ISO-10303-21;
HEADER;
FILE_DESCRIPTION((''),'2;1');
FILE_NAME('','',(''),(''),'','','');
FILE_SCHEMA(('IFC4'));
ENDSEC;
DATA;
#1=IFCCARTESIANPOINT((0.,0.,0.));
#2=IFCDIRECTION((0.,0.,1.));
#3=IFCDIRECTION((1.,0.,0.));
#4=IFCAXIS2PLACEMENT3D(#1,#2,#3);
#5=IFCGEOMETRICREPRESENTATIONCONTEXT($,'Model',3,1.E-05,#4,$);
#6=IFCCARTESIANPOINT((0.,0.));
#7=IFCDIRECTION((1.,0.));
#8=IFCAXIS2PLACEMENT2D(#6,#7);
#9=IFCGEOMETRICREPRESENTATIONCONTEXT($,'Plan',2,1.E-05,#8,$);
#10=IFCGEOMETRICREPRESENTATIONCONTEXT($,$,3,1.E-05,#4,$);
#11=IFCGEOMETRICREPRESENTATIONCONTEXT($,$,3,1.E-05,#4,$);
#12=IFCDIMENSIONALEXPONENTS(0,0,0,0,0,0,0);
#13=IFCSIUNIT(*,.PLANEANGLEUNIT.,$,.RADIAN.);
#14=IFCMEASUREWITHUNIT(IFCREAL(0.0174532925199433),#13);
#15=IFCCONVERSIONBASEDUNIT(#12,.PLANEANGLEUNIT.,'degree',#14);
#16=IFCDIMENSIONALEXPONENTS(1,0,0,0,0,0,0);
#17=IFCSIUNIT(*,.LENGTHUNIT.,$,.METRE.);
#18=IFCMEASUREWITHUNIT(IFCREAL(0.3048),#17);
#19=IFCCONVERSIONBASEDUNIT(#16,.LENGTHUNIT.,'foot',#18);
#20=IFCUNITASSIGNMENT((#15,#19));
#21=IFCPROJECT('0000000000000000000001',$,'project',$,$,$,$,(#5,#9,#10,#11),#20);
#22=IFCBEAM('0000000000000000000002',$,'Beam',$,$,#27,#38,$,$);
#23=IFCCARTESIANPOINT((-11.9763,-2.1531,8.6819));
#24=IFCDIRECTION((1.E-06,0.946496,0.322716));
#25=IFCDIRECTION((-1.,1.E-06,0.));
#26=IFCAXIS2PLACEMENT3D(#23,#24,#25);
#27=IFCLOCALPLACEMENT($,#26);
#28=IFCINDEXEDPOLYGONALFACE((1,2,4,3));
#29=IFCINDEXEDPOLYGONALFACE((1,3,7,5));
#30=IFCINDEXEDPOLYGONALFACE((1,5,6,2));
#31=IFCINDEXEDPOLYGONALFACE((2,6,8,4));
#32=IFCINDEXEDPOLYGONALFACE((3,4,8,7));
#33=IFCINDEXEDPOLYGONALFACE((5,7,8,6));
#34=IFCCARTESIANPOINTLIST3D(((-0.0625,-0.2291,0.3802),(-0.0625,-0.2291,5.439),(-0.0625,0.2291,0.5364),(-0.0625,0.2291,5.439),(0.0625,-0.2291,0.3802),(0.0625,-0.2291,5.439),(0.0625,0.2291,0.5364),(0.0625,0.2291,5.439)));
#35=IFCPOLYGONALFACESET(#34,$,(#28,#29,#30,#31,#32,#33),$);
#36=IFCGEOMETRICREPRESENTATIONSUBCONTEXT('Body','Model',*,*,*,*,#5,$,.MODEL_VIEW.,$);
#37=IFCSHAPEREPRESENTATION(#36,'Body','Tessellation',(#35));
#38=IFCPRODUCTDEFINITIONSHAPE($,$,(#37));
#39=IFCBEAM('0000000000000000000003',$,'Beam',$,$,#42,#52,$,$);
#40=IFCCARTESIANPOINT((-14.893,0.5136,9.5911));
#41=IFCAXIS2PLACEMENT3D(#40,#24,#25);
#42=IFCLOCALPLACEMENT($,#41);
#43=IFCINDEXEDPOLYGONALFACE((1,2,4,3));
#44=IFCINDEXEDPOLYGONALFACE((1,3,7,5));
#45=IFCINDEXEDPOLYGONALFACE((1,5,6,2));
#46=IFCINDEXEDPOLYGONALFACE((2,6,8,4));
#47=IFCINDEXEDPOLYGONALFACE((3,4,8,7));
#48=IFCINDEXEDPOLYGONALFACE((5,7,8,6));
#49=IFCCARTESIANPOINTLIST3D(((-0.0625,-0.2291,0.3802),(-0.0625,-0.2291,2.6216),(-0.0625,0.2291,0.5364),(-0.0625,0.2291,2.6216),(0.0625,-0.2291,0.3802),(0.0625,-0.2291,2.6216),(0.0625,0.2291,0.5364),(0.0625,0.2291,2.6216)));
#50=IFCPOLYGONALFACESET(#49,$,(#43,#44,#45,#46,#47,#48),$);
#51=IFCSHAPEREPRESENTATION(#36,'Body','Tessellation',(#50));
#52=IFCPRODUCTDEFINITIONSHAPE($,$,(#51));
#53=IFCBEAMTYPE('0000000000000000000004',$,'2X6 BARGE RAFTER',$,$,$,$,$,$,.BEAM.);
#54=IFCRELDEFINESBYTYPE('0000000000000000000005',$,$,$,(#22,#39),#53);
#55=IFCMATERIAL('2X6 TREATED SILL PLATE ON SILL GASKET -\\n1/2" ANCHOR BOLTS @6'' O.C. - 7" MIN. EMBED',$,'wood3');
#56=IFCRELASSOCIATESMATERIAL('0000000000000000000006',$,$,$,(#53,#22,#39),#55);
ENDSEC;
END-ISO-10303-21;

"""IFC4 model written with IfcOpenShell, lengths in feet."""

from ifc_helpers import new_model, entity, si_unit, converted_unit, frame, origin_with_axes, origin_2d_with_axis, place, context, subcontext, project, rectangle, extrude, clip, halfspace, material, material_profile, profile_set, profile_usage, type_object, element, save


model = new_model("IFC4")

# Units and contexts
model_context = context("Model", 3, precision=1e-05, world=origin_with_axes())
plan_context = context("Plan", 2, precision=1e-05, world=origin_2d_with_axis())
context_of_model_1 = context(None, 3, precision=1e-05, world=origin_with_axes())
context_of_model_2 = context(None, 3, precision=1e-05, world=origin_with_axes())
body_context = subcontext(model_context, "Body", "Model", "MODEL_VIEW")
ifc_project = project(units=[converted_unit("PLANEANGLEUNIT", "degree", entity("IfcReal", 0.0174532925199433), si_unit("PLANEANGLEUNIT", "RADIAN"), dimensions=[0, 0, 0, 0, 0, 0, 0]), converted_unit("LENGTHUNIT", "foot", entity("IfcReal", 0.3048), si_unit("LENGTHUNIT", "METRE"), dimensions=[1, 0, 0, 0, 0, 0, 0])], contexts=[model_context, plan_context, context_of_model_1, context_of_model_2])

# Beams
ifc_material_1 = material(Name="2X6 TREATED SILL PLATE ON SILL GASKET -\\n1/2\" ANCHOR BOLTS @6' O.C. - 7\" MIN. EMBED", Category="wood3")
ifc_material_profile_1 = material_profile(ifc_material_1, rectangle(XDim=0.125, YDim=0.4583))
ifc_profile_set_1 = profile_set([ifc_material_profile_1])
beam_type_1 = type_object("IfcBeamType", Name="2X6 BARGE RAFTER", PredefinedType="BEAM", material=ifc_profile_set_1)
ifc_profile_usage_1 = profile_usage(ifc_profile_set_1, cardinal=5)
beam_1_placement = place(None, frame((-11.9763, -2.1531, 8.6819), z_axis=(0.000001, 0.946496, 0.322716), x_axis=(-1.0, 0.000001, 0.0)))
element("IfcBeam", 1, at=beam_1_placement, type_object=beam_type_1, material=ifc_profile_usage_1, Name="Beam", context=body_context, shape_type="Clipping", body=[
    clip(extrude(rectangle(XDim=0.125, YDim=0.4583), origin_with_axes(), (0.0, 0.0, 1.0), 5.439), halfspace(frame((-1.2845, -0.5322, 0.2768), z_axis=(-0.000001, 0.322716, -0.946496), x_axis=(1.0, 0.000003, 0.0)), False)),
])
ifc_profile_usage_2 = profile_usage(ifc_profile_set_1, cardinal=5)
beam_2_placement = place(None, frame((-14.893, 0.5136, 9.5911), z_axis=(0.000001, 0.946496, 0.322716), x_axis=(-1.0, 0.000001, 0.0)))
element("IfcBeam", 2, at=beam_2_placement, type_object=beam_type_1, material=ifc_profile_usage_2, Name="Beam", context=body_context, shape_type="Clipping", body=[
    clip(extrude(rectangle(XDim=0.125, YDim=0.4583), origin_with_axes(), (0.0, 0.0, 1.0), 2.6216), halfspace(frame((-4.1386, -1.3731, -0.0099), z_axis=(-0.000001, 0.322716, -0.946496), x_axis=(1.0, 0.000003, 0.0)), False)),
])

save(model, "model.ifc")
